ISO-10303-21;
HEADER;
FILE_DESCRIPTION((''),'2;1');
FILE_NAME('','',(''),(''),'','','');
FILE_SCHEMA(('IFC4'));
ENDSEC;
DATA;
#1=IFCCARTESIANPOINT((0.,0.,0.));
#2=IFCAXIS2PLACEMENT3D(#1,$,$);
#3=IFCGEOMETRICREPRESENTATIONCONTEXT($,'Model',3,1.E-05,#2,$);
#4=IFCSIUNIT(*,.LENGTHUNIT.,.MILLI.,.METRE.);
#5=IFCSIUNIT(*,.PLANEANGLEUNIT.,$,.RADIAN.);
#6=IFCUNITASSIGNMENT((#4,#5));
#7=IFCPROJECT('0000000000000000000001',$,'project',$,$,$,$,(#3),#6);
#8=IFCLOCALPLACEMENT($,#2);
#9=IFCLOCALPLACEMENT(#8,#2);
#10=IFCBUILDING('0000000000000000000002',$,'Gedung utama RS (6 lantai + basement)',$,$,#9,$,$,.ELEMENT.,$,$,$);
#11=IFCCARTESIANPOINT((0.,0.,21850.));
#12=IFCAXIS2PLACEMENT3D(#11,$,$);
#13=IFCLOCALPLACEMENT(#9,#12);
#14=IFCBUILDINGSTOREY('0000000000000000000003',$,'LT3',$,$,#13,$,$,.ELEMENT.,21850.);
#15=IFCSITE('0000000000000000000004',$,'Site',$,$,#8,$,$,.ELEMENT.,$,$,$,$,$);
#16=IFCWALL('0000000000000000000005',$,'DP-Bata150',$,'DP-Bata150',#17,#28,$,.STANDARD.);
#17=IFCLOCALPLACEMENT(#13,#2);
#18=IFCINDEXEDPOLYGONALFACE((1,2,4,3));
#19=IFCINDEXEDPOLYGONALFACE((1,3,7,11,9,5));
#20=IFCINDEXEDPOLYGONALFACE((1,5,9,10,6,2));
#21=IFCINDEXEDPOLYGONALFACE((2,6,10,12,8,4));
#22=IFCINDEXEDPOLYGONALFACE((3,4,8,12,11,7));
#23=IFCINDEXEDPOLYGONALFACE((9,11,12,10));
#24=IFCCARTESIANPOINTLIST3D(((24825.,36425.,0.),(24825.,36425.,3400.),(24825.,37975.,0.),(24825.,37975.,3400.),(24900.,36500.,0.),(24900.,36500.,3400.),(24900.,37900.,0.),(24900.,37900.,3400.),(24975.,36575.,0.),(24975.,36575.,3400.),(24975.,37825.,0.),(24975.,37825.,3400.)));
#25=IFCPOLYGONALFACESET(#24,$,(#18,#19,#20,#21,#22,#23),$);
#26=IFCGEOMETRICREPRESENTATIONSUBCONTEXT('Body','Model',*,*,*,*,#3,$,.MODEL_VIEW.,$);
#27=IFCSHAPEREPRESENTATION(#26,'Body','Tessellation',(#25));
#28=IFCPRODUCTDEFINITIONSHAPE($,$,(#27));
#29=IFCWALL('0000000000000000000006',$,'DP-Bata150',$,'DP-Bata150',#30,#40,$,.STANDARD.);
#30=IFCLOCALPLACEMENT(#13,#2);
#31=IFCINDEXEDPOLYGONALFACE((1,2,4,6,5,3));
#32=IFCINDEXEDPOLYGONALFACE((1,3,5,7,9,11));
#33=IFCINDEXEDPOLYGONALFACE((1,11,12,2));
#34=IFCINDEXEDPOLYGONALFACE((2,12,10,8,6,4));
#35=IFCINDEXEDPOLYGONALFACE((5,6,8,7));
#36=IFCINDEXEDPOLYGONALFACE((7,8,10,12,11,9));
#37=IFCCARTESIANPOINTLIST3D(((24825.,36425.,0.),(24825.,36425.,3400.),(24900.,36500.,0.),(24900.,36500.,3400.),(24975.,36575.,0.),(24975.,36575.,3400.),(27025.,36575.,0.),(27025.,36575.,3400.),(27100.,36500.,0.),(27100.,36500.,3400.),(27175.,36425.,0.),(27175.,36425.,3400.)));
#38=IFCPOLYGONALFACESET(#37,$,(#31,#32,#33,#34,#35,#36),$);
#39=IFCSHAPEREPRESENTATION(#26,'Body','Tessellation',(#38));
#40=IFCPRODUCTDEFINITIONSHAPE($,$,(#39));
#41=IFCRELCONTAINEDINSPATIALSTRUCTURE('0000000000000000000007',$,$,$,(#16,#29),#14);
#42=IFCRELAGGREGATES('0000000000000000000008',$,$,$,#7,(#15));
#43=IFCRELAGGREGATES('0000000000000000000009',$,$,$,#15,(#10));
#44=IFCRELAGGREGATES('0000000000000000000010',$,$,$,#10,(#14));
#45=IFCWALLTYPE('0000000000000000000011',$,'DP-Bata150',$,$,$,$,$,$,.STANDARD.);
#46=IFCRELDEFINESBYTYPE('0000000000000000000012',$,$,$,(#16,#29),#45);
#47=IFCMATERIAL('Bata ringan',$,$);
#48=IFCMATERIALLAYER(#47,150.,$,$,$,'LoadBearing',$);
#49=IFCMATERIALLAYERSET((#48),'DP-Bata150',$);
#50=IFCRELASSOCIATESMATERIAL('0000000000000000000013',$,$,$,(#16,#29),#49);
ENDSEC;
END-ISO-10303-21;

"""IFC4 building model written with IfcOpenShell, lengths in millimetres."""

from ifc_helpers import new_model, si_unit, frame, origin, place, context, subcontext, project, spatial, polyline, outline, extrude, material, layer, layer_set, layer_usage, type_object, element, save


model = new_model("IFC4")

# Units and contexts
model_context = context("Model", 3, precision=1e-05, world=origin())
body_context = subcontext(model_context, "Body", "Model", "MODEL_VIEW")
ifc_project = project(units=[si_unit("LENGTHUNIT", "METRE", prefix="MILLI"), si_unit("PLANEANGLEUNIT", "RADIAN")], contexts=[model_context])

# Site, building, storey
site_placement = place(None, origin())
site = spatial("IfcSite", under=ifc_project, at=site_placement, Name="Site", CompositionType="ELEMENT")
building_placement = place(site_placement, origin())
building = spatial("IfcBuilding", under=site, at=building_placement, Name="Gedung utama RS (6 lantai + basement)", CompositionType="ELEMENT")
storey_placement = place(building_placement, frame((0.0, 0.0, 21850.0)))
storey = spatial("IfcBuildingStorey", under=building, at=storey_placement, Name="LT3", CompositionType="ELEMENT", Elevation=21850.0)

# Walls
ifc_material_1 = material(Name="Bata ringan")
ifc_layer_1 = layer(ifc_material_1, 150.0, Category="LoadBearing")
ifc_layer_set_1 = layer_set([ifc_layer_1], Name="DP-Bata150")
ifc_layer_usage_1 = layer_usage(ifc_layer_set_1, "AXIS2", "NEGATIVE", 75.0)
wall_type_1 = type_object("IfcWallType", Name="DP-Bata150", PredefinedType="STANDARD")
wall_1_placement = place(storey_placement, frame((24900.0, 37900.0, 0.0), z_axis=(0.0, 0.0, 1.0), x_axis=(0.0, -1.0, 0.0)))
element("IfcWall", 1, at=wall_1_placement, inside=storey, type_object=wall_type_1, material=ifc_layer_usage_1, Name="DP-Bata150", ObjectType="DP-Bata150", PredefinedType="STANDARD", context=body_context, shape_type="SweptSolid", body=[
    extrude(outline(polyline([(-75.0, -75.0), (0.0, 0.0), (75.0, 75.0), (1325.0, 75.0), (1400.0, 0.0), (1475.0, -75.0), (-75.0, -75.0)])), origin(), (0.0, 0.0, 1.0), 3400.0),
])
wall_2_placement = place(storey_placement, frame((24900.0, 36500.0, 0.0), z_axis=(0.0, 0.0, 1.0), x_axis=(1.0, 0.0, 0.0)))
element("IfcWall", 2, at=wall_2_placement, inside=storey, type_object=wall_type_1, material=ifc_layer_usage_1, Name="DP-Bata150", ObjectType="DP-Bata150", PredefinedType="STANDARD", context=body_context, shape_type="SweptSolid", body=[
    extrude(outline(polyline([(-75.0, -75.0), (0.0, 0.0), (75.0, 75.0), (2125.0, 75.0), (2200.0, 0.0), (2275.0, -75.0), (-75.0, -75.0)])), origin(), (0.0, 0.0, 1.0), 3400.0),
])

save(model, "model.ifc")
